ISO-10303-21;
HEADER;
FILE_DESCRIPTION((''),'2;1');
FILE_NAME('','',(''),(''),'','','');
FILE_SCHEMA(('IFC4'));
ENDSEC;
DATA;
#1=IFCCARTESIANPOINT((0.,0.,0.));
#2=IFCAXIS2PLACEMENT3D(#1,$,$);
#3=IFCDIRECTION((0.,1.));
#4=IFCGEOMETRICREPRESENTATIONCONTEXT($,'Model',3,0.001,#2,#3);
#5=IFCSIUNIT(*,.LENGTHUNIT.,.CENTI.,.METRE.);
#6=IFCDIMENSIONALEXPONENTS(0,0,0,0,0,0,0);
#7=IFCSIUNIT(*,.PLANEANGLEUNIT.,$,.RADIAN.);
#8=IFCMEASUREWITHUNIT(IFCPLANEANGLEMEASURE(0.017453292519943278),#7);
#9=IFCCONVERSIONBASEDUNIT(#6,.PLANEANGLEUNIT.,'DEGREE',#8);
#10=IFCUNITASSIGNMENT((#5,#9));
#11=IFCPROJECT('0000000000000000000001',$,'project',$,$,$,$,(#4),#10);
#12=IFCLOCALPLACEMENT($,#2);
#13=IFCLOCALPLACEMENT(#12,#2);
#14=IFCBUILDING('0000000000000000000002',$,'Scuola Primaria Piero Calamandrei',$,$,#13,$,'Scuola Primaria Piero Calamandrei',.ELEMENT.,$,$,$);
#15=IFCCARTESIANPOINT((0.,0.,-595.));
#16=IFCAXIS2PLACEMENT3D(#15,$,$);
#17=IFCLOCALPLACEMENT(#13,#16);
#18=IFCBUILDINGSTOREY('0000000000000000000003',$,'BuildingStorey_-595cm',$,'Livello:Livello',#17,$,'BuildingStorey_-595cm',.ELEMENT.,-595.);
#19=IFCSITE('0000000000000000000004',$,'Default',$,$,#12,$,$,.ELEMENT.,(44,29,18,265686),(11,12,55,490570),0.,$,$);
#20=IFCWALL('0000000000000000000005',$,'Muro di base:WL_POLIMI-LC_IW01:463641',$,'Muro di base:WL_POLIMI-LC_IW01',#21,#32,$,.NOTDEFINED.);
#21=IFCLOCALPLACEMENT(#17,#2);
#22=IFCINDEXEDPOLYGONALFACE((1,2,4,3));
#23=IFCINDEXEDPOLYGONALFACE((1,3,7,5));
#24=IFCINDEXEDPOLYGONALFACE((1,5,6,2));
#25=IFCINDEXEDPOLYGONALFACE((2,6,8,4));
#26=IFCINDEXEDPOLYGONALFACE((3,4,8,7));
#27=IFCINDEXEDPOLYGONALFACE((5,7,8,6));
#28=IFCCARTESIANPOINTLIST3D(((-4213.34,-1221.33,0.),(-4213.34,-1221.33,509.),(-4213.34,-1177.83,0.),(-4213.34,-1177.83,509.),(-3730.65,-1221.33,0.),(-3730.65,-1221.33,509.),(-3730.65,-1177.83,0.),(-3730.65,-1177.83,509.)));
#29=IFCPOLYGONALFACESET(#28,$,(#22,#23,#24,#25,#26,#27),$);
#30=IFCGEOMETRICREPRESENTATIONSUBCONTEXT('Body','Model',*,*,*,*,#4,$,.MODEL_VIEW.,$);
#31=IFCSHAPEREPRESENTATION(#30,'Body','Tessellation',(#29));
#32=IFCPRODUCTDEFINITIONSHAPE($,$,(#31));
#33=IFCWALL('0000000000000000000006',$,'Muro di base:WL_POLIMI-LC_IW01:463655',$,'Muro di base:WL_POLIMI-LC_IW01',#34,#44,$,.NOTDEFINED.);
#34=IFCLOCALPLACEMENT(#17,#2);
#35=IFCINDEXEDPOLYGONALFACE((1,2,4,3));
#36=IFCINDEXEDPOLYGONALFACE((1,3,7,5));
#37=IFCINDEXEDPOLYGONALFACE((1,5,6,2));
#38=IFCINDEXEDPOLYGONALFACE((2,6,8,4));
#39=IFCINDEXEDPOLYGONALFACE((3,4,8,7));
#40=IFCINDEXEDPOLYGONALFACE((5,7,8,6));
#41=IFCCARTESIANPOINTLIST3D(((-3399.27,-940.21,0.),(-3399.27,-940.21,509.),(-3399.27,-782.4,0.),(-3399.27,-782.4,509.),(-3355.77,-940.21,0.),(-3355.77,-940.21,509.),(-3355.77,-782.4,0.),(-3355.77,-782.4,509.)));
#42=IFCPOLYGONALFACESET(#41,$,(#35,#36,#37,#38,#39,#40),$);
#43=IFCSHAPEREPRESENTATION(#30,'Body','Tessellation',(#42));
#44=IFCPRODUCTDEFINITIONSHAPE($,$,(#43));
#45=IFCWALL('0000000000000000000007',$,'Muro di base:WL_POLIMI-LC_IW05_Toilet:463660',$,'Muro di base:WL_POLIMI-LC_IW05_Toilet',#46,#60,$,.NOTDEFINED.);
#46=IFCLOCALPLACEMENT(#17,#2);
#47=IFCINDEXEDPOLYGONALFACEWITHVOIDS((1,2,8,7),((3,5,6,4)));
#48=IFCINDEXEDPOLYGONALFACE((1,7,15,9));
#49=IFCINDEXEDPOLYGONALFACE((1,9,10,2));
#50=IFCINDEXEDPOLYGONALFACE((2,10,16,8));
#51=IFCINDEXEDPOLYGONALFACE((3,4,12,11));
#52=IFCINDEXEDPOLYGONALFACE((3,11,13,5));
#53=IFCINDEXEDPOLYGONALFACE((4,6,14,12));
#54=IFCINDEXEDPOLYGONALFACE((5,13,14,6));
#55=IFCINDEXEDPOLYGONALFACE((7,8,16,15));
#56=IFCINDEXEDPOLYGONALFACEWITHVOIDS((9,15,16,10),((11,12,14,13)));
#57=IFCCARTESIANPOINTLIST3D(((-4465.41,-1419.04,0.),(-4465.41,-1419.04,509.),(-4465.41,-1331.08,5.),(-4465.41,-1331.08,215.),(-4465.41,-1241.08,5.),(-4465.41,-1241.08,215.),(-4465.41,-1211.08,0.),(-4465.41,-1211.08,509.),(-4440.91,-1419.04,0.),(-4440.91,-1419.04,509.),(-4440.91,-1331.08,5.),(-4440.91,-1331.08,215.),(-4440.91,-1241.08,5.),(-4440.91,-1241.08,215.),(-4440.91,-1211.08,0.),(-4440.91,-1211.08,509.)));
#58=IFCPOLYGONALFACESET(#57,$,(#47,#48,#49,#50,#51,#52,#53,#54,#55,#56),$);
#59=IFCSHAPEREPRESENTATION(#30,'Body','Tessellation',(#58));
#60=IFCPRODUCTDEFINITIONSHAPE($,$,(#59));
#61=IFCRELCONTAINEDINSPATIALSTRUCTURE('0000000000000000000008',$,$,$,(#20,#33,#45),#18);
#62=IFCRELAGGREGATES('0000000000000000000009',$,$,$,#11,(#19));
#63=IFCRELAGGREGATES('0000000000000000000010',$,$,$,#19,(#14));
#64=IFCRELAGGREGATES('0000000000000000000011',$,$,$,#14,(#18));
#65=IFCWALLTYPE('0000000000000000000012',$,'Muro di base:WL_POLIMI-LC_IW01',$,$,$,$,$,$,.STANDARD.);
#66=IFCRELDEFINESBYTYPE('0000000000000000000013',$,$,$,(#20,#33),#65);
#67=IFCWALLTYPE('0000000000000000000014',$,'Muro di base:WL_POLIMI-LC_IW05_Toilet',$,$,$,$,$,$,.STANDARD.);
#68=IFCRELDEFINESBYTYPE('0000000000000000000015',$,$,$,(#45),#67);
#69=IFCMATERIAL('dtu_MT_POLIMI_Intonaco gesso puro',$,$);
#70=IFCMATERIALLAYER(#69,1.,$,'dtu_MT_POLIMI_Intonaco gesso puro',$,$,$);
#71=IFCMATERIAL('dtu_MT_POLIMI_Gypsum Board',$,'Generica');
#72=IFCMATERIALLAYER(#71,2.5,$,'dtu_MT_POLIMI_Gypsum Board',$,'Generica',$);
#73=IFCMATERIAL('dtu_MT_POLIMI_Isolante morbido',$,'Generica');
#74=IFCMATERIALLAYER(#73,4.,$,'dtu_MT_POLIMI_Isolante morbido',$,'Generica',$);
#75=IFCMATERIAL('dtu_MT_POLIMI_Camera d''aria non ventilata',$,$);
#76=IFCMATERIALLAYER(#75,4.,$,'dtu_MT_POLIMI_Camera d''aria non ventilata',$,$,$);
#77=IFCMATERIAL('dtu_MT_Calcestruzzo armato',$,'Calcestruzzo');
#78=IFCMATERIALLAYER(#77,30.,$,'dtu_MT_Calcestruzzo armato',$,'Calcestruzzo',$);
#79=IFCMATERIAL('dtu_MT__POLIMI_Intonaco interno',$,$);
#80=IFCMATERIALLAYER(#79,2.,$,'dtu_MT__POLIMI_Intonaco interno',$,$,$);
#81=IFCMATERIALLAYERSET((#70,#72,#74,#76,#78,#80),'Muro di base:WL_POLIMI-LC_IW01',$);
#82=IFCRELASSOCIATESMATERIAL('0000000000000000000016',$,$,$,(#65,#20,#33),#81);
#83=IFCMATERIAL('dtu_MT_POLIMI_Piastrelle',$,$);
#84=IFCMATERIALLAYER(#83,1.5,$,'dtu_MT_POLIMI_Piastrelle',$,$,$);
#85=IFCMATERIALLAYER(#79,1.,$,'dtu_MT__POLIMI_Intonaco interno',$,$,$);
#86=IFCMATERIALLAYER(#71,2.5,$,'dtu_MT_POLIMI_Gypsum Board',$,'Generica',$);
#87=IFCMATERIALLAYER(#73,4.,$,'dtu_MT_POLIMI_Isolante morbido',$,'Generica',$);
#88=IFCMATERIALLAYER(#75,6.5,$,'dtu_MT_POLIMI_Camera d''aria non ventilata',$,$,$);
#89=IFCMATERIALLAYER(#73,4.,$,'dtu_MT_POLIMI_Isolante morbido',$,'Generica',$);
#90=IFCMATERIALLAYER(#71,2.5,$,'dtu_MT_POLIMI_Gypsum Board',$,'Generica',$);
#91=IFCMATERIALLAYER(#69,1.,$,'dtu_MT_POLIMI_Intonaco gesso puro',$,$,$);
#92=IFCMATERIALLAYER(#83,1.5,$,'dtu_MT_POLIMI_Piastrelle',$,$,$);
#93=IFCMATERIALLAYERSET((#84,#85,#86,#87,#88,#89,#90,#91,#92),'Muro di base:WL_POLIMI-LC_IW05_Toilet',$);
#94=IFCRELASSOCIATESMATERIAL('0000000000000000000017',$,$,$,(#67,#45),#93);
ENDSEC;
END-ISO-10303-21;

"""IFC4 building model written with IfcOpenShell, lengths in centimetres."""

from ifc_helpers import new_model, entity, si_unit, converted_unit, direction, frame, frame_2d, origin, place, context, subcontext, project, spatial, rectangle, extrude, material, layer, layer_set, layer_usage, type_object, element, save


model = new_model("IFC4")

# Units and contexts
model_context = context("Model", 3, precision=0.001, world=origin(), true_north=direction((0.0, 1.0)))
body_context = subcontext(model_context, "Body", "Model", "MODEL_VIEW")
ifc_project = project(units=[si_unit("LENGTHUNIT", "METRE", prefix="CENTI"), converted_unit("PLANEANGLEUNIT", "DEGREE", entity("IfcPlaneAngleMeasure", 0.017453292519943278), si_unit("PLANEANGLEUNIT", "RADIAN"), dimensions=[0, 0, 0, 0, 0, 0, 0])], contexts=[model_context])

# Site, building, storey
site_placement = place(None, origin())
site = spatial("IfcSite", under=ifc_project, at=site_placement, Name="Default", CompositionType="ELEMENT", RefLatitude=(44, 29, 18, 265686), RefLongitude=(11, 12, 55, 490570), RefElevation=0.0)
building_placement = place(site_placement, origin())
building = spatial("IfcBuilding", under=site, at=building_placement, Name="Scuola Primaria Piero Calamandrei", LongName="Scuola Primaria Piero Calamandrei", CompositionType="ELEMENT")
storey_placement = place(building_placement, frame((0.0, 0.0, -595.0)))
storey = spatial("IfcBuildingStorey", under=building, at=storey_placement, Name="BuildingStorey_-595cm", ObjectType="Livello:Livello", LongName="BuildingStorey_-595cm", CompositionType="ELEMENT", Elevation=-595.0)

# Shared definitions
ifc_material_1 = material(Name="dtu_MT__POLIMI_Intonaco interno")
ifc_material_2 = material(Name="dtu_MT_POLIMI_Gypsum Board", Category="Generica")
ifc_material_3 = material(Name="dtu_MT_POLIMI_Isolante morbido", Category="Generica")
ifc_material_4 = material(Name="dtu_MT_POLIMI_Camera d'aria non ventilata")
ifc_material_5 = material(Name="dtu_MT_POLIMI_Intonaco gesso puro")

# Walls
ifc_material_6 = material(Name="dtu_MT_POLIMI_Piastrelle")
ifc_layer_1 = layer(ifc_material_5, 1.0, Name="dtu_MT_POLIMI_Intonaco gesso puro")
ifc_layer_2 = layer(ifc_material_2, 2.5, Name="dtu_MT_POLIMI_Gypsum Board", Category="Generica")
ifc_layer_3 = layer(ifc_material_3, 4.0, Name="dtu_MT_POLIMI_Isolante morbido", Category="Generica")
ifc_layer_4 = layer(ifc_material_4, 4.0, Name="dtu_MT_POLIMI_Camera d'aria non ventilata")
ifc_material_7 = material(Name="dtu_MT_Calcestruzzo armato", Category="Calcestruzzo")
ifc_layer_5 = layer(ifc_material_7, 30.0, Name="dtu_MT_Calcestruzzo armato", Category="Calcestruzzo")
ifc_layer_6 = layer(ifc_material_1, 2.0, Name="dtu_MT__POLIMI_Intonaco interno")
ifc_layer_set_1 = layer_set([ifc_layer_1, ifc_layer_2, ifc_layer_3, ifc_layer_4, ifc_layer_5, ifc_layer_6], Name="Muro di base:WL_POLIMI-LC_IW01")
ifc_layer_usage_1 = layer_usage(ifc_layer_set_1, "AXIS2", "NEGATIVE", 21.75)
wall_type_1 = type_object("IfcWallType", Name="Muro di base:WL_POLIMI-LC_IW01", PredefinedType="STANDARD", material=ifc_layer_set_1)
wall_1_placement = place(storey_placement, frame((-4213.34, -1199.58, 0.0)))
element("IfcWall", 1, at=wall_1_placement, inside=storey, type_object=wall_type_1, material=ifc_layer_usage_1, Name="Muro di base:WL_POLIMI-LC_IW01:463641", ObjectType="Muro di base:WL_POLIMI-LC_IW01", PredefinedType="NOTDEFINED", context=body_context, shape_type="SweptSolid", body=[
    extrude(rectangle(XDim=482.69, YDim=43.5, at=frame_2d((241.35, 0.0), x_axis=(-1.0, 0.0))), origin(), (0.0, 0.0, 1.0), 509.0),
])
ifc_layer_usage_2 = layer_usage(ifc_layer_set_1, "AXIS2", "NEGATIVE", 21.75)
wall_2_placement = place(storey_placement, frame((-3377.52, -782.4, 0.0), z_axis=(0.0, 0.0, 1.0), x_axis=(0.0, -1.0, 0.0)))
element("IfcWall", 2, at=wall_2_placement, inside=storey, type_object=wall_type_1, material=ifc_layer_usage_2, Name="Muro di base:WL_POLIMI-LC_IW01:463655", ObjectType="Muro di base:WL_POLIMI-LC_IW01", PredefinedType="NOTDEFINED", context=body_context, shape_type="SweptSolid", body=[
    extrude(rectangle(XDim=157.81, YDim=43.5, at=frame_2d((78.91, 0.0), x_axis=(-1.0, 0.0))), origin(), (0.0, 0.0, 1.0), 509.0),
])

# Wall, opening
ifc_layer_7 = layer(ifc_material_6, 1.5, Name="dtu_MT_POLIMI_Piastrelle")
ifc_layer_8 = layer(ifc_material_1, 1.0, Name="dtu_MT__POLIMI_Intonaco interno")
ifc_layer_9 = layer(ifc_material_2, 2.5, Name="dtu_MT_POLIMI_Gypsum Board", Category="Generica")
ifc_layer_10 = layer(ifc_material_3, 4.0, Name="dtu_MT_POLIMI_Isolante morbido", Category="Generica")
ifc_layer_11 = layer(ifc_material_4, 6.5, Name="dtu_MT_POLIMI_Camera d'aria non ventilata")
ifc_layer_12 = layer(ifc_material_3, 4.0, Name="dtu_MT_POLIMI_Isolante morbido", Category="Generica")
ifc_layer_13 = layer(ifc_material_2, 2.5, Name="dtu_MT_POLIMI_Gypsum Board", Category="Generica")
ifc_layer_14 = layer(ifc_material_5, 1.0, Name="dtu_MT_POLIMI_Intonaco gesso puro")
ifc_layer_15 = layer(ifc_material_6, 1.5, Name="dtu_MT_POLIMI_Piastrelle")
ifc_layer_set_2 = layer_set([ifc_layer_7, ifc_layer_8, ifc_layer_9, ifc_layer_10, ifc_layer_11, ifc_layer_12, ifc_layer_13, ifc_layer_14, ifc_layer_15], Name="Muro di base:WL_POLIMI-LC_IW05_Toilet")
ifc_layer_usage_3 = layer_usage(ifc_layer_set_2, "AXIS2", "NEGATIVE", 12.25)
wall_type_2 = type_object("IfcWallType", Name="Muro di base:WL_POLIMI-LC_IW05_Toilet", PredefinedType="STANDARD", material=ifc_layer_set_2)
wall_3_placement = place(storey_placement, frame((-4453.16, -1211.08, 0.0), z_axis=(0.0, 0.0, 1.0), x_axis=(0.0, -1.0, 0.0)))
wall_3 = element("IfcWall", 3, at=wall_3_placement, inside=storey, type_object=wall_type_2, material=ifc_layer_usage_3, Name="Muro di base:WL_POLIMI-LC_IW05_Toilet:463660", ObjectType="Muro di base:WL_POLIMI-LC_IW05_Toilet", PredefinedType="NOTDEFINED", context=body_context, shape_type="SweptSolid", body=[
    extrude(rectangle(XDim=207.96, YDim=24.5, at=frame_2d((103.98, 0.0), x_axis=(-1.0, 0.0))), origin(), (0.0, 0.0, 1.0), 509.0),
])
opening_1_placement = place(wall_3_placement, frame((120.0, 12.25, 5.0)))
element("IfcOpeningElement", 4, at=opening_1_placement, cuts=wall_3, PredefinedType="OPENING", context=body_context, shape_type="SweptSolid", body=[
    extrude(rectangle(XDim=210.0, YDim=90.0, at=frame_2d((105.0, 45.0), x_axis=(1.0, 0.0))), frame((0.0, 0.0, 0.0), z_axis=(0.0, -1.0, 0.0), x_axis=(0.0, 0.0, 1.0)), (0.0, 0.0, 1.0), 24.5),
])

save(model, "model.ifc")
